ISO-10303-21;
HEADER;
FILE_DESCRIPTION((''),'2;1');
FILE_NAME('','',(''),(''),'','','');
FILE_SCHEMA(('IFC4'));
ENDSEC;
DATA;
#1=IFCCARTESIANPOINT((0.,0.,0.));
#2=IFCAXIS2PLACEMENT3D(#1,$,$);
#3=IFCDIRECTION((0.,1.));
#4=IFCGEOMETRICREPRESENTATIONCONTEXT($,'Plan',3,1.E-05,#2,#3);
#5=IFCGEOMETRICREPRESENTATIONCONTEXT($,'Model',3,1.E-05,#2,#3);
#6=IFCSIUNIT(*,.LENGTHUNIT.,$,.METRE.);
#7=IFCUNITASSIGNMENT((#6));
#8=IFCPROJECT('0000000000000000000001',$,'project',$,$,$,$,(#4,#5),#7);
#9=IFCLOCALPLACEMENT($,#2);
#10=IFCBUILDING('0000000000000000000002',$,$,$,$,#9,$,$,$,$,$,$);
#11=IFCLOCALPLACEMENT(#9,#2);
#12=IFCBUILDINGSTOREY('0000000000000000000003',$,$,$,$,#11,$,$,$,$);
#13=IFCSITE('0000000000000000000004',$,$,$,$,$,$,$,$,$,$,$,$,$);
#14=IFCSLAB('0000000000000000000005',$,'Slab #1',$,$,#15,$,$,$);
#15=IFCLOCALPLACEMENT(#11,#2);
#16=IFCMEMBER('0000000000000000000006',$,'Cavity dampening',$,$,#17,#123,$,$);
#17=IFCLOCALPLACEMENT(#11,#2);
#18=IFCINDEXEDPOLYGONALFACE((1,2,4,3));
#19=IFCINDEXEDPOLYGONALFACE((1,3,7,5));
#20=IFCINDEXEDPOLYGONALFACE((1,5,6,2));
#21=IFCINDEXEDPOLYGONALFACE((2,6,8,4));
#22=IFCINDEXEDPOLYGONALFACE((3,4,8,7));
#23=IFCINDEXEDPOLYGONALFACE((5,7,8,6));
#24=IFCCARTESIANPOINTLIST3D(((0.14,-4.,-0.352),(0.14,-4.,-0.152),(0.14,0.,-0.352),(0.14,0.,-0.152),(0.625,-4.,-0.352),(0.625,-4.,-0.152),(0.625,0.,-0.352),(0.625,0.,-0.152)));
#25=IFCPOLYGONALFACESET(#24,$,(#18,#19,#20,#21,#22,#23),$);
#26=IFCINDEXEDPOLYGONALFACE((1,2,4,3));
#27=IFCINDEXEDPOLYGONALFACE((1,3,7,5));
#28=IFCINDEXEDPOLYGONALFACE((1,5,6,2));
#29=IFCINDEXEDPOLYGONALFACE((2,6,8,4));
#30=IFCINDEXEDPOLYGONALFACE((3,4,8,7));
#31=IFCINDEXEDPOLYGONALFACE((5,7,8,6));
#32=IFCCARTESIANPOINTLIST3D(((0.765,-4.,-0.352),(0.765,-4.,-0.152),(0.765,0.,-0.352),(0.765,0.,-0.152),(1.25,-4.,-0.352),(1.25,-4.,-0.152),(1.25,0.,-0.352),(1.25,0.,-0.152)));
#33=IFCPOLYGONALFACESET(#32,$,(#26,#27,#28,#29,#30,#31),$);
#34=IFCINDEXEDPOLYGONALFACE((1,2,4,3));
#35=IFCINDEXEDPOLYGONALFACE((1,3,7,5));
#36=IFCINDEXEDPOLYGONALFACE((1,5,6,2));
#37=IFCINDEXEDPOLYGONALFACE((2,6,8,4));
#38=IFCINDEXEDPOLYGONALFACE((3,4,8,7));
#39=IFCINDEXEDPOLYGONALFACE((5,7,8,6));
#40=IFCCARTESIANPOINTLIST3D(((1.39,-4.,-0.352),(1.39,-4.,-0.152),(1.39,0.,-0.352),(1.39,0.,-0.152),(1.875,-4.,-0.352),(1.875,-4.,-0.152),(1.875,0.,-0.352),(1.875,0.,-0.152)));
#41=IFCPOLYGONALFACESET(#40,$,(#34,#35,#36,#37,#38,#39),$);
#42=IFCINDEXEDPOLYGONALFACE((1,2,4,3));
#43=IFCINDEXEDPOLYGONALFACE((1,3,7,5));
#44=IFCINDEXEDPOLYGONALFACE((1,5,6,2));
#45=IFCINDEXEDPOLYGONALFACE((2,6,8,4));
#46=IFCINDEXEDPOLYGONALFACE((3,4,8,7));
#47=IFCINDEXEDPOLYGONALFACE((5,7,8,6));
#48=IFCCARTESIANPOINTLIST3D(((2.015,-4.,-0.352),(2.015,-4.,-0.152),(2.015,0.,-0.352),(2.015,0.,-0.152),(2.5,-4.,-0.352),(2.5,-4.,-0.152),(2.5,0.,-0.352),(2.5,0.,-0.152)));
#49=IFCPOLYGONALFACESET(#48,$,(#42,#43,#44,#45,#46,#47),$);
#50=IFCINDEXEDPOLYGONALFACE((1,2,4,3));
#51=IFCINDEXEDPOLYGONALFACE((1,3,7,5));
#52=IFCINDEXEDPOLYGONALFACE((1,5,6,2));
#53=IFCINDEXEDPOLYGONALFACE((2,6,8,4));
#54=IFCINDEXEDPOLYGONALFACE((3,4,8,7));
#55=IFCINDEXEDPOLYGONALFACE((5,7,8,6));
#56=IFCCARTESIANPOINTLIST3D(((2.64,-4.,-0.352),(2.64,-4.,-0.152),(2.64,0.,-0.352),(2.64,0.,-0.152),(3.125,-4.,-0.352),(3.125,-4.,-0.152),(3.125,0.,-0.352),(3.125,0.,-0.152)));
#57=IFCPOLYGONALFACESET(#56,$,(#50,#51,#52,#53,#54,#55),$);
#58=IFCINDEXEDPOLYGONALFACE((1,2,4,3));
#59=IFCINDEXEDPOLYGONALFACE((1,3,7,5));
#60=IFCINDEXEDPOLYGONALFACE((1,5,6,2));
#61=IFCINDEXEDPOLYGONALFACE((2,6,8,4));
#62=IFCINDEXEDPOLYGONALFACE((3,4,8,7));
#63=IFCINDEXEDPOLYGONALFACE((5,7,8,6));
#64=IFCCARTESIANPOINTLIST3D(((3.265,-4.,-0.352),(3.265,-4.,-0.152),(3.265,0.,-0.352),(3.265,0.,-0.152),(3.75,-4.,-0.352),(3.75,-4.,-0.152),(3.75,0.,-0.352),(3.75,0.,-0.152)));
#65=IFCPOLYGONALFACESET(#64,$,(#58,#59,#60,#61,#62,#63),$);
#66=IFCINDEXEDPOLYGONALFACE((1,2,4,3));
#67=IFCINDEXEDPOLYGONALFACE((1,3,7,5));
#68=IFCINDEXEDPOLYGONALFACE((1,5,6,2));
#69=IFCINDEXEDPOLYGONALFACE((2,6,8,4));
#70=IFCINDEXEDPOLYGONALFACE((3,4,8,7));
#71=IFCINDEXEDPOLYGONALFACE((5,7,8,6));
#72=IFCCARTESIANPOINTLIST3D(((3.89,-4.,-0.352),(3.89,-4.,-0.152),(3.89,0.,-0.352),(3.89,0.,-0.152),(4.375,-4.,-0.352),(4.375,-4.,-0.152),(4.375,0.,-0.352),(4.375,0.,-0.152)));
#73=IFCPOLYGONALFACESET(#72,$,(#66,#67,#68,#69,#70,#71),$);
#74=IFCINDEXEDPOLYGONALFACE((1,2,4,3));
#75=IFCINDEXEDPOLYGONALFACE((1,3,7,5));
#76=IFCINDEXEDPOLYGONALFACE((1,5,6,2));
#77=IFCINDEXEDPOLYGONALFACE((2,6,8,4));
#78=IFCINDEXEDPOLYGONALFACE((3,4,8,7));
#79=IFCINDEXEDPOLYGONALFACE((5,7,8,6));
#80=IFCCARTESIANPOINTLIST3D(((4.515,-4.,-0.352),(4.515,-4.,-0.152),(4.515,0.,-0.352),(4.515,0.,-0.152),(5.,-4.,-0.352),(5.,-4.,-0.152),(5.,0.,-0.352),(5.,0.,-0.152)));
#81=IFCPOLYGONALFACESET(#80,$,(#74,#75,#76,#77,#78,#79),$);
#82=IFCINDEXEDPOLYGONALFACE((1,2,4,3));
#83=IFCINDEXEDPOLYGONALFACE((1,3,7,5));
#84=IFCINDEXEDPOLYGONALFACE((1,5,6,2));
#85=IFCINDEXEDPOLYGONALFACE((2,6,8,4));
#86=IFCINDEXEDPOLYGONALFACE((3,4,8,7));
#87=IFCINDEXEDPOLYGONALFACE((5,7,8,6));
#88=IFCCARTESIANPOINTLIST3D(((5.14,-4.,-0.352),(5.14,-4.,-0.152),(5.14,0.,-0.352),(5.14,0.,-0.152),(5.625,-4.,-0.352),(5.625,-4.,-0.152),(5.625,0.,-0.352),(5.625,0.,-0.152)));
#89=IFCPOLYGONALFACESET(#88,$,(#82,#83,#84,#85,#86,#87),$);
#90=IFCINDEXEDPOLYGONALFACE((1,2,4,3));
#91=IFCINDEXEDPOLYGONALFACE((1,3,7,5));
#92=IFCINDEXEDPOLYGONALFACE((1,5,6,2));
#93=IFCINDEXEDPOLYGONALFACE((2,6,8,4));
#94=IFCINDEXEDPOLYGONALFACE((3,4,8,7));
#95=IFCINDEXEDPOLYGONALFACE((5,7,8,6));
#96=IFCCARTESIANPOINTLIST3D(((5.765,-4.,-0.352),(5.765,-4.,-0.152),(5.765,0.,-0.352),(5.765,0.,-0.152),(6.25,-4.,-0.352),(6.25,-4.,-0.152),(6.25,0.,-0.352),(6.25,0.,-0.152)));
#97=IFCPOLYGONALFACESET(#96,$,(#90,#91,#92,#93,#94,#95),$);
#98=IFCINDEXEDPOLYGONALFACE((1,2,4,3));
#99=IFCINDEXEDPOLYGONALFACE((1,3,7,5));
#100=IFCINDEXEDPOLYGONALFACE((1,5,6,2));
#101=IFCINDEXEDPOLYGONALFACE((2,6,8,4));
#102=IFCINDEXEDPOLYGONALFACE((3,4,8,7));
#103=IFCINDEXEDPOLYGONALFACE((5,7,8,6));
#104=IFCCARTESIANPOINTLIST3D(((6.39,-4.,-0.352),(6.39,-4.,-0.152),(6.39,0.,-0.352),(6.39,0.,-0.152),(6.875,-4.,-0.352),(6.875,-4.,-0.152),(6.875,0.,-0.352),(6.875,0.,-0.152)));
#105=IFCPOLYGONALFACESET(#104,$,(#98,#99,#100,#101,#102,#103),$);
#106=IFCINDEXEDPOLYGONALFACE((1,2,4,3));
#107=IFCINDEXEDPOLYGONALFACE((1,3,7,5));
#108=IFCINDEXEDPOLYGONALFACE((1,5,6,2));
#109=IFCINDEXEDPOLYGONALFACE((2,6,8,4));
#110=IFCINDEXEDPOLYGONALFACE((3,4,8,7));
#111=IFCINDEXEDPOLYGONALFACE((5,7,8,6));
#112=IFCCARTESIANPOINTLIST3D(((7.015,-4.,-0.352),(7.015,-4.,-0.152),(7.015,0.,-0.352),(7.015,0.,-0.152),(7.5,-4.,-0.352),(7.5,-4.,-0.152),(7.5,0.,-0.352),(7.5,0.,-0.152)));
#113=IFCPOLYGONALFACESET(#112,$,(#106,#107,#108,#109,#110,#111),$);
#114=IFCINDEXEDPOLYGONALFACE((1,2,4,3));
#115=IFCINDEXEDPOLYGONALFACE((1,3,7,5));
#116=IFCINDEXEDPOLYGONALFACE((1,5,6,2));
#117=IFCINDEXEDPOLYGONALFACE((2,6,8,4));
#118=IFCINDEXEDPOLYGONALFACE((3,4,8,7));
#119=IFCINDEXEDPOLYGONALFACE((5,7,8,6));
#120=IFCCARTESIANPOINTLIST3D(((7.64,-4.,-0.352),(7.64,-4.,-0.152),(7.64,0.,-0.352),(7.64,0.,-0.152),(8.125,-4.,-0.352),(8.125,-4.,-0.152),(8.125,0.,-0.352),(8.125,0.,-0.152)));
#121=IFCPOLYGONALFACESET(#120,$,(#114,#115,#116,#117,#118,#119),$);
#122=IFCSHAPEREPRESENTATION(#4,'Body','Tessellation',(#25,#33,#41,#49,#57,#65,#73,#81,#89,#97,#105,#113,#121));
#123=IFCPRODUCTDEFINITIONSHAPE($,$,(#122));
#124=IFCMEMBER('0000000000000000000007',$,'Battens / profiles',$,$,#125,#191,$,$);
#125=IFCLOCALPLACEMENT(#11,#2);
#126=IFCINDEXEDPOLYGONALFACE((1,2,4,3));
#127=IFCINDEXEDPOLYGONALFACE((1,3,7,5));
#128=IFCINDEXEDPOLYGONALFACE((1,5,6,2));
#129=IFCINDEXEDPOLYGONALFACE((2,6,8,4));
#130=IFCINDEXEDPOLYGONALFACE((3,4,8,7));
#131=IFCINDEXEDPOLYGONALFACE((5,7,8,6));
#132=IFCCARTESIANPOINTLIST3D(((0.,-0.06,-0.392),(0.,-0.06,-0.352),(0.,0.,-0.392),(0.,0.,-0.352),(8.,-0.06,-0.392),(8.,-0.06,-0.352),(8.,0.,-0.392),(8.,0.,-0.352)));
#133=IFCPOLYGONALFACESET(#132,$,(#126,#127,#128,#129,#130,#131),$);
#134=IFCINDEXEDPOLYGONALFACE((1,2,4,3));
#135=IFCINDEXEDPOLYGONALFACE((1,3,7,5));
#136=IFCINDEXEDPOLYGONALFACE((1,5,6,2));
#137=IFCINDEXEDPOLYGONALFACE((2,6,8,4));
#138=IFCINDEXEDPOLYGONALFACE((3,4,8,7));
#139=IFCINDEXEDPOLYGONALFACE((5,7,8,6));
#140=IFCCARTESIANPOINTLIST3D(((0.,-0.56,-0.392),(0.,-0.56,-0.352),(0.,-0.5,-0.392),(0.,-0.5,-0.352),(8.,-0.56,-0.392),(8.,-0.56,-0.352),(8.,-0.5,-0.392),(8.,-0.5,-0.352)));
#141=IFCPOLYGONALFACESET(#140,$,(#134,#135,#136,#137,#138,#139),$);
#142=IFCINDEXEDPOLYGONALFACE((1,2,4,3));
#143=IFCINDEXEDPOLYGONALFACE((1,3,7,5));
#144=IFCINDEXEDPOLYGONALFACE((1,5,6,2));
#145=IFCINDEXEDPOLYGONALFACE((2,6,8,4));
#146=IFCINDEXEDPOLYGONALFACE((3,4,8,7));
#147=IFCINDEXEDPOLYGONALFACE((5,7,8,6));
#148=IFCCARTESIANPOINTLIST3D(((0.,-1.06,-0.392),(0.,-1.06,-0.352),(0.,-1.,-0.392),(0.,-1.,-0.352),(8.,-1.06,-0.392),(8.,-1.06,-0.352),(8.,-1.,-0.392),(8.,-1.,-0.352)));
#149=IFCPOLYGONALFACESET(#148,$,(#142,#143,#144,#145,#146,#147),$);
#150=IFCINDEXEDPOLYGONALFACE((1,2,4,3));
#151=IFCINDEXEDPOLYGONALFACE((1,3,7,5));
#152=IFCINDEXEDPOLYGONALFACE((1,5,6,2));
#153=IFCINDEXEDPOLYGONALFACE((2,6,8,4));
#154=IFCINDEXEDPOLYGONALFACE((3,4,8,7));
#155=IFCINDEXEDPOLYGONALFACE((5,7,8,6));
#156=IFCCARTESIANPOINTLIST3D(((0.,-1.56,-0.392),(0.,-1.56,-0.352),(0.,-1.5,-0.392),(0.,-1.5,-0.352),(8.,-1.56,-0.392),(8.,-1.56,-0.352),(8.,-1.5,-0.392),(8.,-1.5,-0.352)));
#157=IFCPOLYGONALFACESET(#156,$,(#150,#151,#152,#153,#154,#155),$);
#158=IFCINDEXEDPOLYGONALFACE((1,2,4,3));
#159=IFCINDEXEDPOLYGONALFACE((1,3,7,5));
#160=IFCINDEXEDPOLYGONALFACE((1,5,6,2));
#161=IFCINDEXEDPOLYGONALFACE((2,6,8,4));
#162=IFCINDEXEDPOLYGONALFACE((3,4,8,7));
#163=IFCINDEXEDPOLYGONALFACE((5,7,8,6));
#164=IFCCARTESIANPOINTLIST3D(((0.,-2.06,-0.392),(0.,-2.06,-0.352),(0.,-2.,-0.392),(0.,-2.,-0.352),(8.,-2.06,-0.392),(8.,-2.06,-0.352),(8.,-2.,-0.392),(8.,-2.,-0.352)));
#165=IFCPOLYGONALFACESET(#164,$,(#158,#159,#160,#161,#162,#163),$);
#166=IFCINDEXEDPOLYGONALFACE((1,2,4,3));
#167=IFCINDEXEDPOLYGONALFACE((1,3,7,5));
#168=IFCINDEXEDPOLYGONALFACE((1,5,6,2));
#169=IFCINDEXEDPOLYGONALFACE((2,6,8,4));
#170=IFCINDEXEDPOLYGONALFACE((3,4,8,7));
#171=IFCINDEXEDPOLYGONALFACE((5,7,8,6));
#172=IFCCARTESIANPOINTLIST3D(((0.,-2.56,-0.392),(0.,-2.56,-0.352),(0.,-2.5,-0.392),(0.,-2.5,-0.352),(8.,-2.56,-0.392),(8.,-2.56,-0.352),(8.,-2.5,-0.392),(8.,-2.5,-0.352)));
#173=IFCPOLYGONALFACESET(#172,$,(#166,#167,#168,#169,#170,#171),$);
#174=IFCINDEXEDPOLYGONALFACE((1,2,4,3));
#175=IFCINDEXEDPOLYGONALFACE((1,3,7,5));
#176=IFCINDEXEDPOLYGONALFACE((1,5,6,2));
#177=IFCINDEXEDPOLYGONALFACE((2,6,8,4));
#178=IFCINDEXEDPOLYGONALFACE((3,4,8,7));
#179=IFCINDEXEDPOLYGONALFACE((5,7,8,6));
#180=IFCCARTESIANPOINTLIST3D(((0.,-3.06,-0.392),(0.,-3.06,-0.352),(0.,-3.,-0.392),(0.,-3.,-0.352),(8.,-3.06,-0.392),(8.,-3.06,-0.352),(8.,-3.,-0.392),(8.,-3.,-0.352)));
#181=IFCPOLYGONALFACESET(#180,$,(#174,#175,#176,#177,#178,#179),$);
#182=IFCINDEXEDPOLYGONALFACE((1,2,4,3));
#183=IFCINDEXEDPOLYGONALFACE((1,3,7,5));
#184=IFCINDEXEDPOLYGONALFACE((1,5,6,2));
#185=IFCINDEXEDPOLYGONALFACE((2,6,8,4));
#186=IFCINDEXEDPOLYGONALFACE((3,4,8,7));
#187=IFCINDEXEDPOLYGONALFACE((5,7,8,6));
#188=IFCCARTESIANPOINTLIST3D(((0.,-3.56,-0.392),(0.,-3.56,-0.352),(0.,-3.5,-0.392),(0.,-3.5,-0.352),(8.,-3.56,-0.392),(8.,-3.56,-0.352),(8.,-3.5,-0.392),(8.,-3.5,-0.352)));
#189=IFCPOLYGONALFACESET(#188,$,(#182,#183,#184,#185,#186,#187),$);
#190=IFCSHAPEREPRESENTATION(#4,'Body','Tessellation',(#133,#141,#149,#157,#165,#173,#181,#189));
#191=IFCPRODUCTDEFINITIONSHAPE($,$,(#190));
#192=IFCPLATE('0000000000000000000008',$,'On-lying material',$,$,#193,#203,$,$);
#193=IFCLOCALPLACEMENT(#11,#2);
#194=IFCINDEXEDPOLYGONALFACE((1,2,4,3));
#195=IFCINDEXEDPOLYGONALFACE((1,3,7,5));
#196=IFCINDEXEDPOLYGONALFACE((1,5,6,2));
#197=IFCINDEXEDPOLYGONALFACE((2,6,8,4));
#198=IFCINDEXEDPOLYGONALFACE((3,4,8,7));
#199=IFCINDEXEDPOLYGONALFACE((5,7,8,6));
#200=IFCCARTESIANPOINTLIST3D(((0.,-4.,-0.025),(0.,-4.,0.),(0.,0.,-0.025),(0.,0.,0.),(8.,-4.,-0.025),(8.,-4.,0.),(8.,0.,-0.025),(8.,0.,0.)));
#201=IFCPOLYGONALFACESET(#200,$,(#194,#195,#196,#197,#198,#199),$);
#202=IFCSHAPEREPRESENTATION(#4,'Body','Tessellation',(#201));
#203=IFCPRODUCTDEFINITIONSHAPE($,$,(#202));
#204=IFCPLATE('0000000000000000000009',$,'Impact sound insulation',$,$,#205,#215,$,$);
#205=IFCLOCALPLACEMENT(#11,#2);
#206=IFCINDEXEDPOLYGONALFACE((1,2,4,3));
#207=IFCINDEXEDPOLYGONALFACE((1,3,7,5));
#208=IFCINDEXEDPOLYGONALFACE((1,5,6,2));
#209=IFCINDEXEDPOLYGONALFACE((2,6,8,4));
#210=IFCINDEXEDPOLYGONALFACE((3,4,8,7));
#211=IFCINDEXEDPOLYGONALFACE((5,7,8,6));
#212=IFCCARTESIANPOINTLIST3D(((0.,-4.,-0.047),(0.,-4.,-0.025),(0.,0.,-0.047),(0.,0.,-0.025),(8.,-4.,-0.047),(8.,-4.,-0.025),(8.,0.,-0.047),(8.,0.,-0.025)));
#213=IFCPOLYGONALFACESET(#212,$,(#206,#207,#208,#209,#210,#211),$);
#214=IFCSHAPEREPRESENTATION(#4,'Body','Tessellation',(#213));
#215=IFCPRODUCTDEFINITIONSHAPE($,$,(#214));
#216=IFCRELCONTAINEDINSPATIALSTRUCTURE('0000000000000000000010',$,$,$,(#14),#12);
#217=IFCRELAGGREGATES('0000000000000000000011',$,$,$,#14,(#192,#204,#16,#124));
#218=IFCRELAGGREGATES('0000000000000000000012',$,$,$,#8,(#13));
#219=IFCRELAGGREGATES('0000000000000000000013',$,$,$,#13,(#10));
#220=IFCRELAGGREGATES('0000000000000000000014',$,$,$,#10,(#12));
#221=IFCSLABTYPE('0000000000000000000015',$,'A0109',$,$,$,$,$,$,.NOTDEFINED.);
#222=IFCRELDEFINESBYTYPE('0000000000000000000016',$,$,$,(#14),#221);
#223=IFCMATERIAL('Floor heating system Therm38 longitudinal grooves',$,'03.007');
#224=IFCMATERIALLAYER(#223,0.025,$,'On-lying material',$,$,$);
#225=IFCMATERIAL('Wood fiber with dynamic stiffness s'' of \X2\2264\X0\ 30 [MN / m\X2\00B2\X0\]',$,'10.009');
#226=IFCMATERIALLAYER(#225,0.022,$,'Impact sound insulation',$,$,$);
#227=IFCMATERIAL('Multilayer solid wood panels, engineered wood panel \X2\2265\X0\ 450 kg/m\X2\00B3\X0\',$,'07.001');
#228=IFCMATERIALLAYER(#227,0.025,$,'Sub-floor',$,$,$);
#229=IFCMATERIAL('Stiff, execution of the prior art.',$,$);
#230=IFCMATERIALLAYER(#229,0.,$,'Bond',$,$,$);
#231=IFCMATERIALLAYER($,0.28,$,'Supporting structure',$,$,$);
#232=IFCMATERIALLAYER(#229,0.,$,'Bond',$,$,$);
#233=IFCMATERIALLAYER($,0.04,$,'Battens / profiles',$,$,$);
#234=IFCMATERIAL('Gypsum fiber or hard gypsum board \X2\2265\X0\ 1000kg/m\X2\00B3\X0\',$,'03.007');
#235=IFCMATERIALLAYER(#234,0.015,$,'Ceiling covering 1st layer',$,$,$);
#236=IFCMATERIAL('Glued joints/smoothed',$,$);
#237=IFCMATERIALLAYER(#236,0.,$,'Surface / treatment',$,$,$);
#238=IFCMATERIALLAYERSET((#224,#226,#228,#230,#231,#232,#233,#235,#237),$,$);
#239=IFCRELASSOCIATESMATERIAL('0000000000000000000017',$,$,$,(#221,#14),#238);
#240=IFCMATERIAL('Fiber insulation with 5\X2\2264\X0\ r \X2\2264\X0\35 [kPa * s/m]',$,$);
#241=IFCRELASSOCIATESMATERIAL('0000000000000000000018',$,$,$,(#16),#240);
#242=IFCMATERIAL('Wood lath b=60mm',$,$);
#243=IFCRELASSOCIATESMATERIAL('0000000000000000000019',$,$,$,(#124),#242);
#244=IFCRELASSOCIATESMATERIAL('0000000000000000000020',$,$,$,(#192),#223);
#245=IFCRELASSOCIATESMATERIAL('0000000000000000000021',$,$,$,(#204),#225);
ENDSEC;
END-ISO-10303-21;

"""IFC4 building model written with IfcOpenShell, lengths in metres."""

from ifc_helpers import new_model, si_unit, direction, frame, frame_2d, origin, origin_with_axes, place, context, project, spatial, rectangle, extrude, material, layer, layer_set, type_object, element, aggregate, save


model = new_model("IFC4")

# Units and contexts
plan_context = context("Plan", 3, precision=1e-05, world=origin(), true_north=direction((0.0, 1.0)))
model_context = context("Model", 3, precision=1e-05, world=origin(), true_north=direction((0.0, 1.0)))
ifc_project = project(units=[si_unit("LENGTHUNIT", "METRE")], contexts=[plan_context, model_context])

# Site, building, storey
site = spatial("IfcSite", under=ifc_project)
building_placement = place(None, origin())
building = spatial("IfcBuilding", under=site, at=building_placement)
storey_placement = place(building_placement, origin())
storey = spatial("IfcBuildingStorey", under=building, at=storey_placement)

# Slab, members, plates
ifc_material_1 = material(Name="Floor heating system Therm38 longitudinal grooves", Category="03.007")
ifc_layer_1 = layer(ifc_material_1, 0.025, Name="On-lying material")
ifc_material_2 = material(Name="Wood fiber with dynamic stiffness s' of ≤ 30 [MN / m²]", Category="10.009")
ifc_layer_2 = layer(ifc_material_2, 0.022, Name="Impact sound insulation")
ifc_material_3 = material(Name="Multilayer solid wood panels, engineered wood panel ≥ 450 kg/m³", Category="07.001")
ifc_layer_3 = layer(ifc_material_3, 0.025, Name="Sub-floor")
ifc_material_4 = material(Name="Stiff, execution of the prior art.")
ifc_layer_4 = layer(ifc_material_4, 0.0, Name="Bond")
ifc_layer_5 = layer(None, 0.28, Name="Supporting structure")
ifc_layer_6 = layer(ifc_material_4, 0.0, Name="Bond")
ifc_layer_7 = layer(None, 0.04, Name="Battens / profiles")
ifc_material_5 = material(Name="Gypsum fiber or hard gypsum board ≥ 1000kg/m³", Category="03.007")
ifc_layer_8 = layer(ifc_material_5, 0.015, Name="Ceiling covering 1st layer")
ifc_material_6 = material(Name="Glued joints/smoothed")
ifc_layer_9 = layer(ifc_material_6, 0.0, Name="Surface / treatment")
ifc_layer_set = layer_set([ifc_layer_1, ifc_layer_2, ifc_layer_3, ifc_layer_4, ifc_layer_5, ifc_layer_6, ifc_layer_7, ifc_layer_8, ifc_layer_9])
slab_type = type_object("IfcSlabType", Name="A0109", PredefinedType="NOTDEFINED", material=ifc_layer_set)
slab_placement = place(None, frame((0.0, 0.0, 0.0), z_axis=(0.0, 0.0, -1.0), x_axis=(1.0, 0.0, 0.0)))
slab = element("IfcSlab", 1, at=slab_placement, inside=storey, type_object=slab_type, material=ifc_layer_set, Name="Slab #1")
ifc_material_7 = material(Name="Fiber insulation with 5≤ r ≤35 [kPa * s/m]")
member_1_placement = place(slab_placement, origin())
member_1 = element("IfcMember", 2, at=member_1_placement, material=ifc_material_7, Name="Cavity dampening", context=plan_context, shape_type="SweptSolid", body=[
    extrude(rectangle(XDim=0.485, YDim=0.2, at=frame_2d((0.2425, 0.1), x_axis=(1.0, 0.0))), frame((0.14, 4.0, 0.152), z_axis=(0.0, -1.0, 0.0), x_axis=(1.0, 0.0, 0.0)), (0.0, 0.0, 1.0), 4.0),
    extrude(rectangle(XDim=0.485, YDim=0.2, at=frame_2d((0.2425, 0.1), x_axis=(1.0, 0.0))), frame((0.765, 4.0, 0.152), z_axis=(0.0, -1.0, 0.0), x_axis=(1.0, 0.0, 0.0)), (0.0, 0.0, 1.0), 4.0),
    extrude(rectangle(XDim=0.485, YDim=0.2, at=frame_2d((0.2425, 0.1), x_axis=(1.0, 0.0))), frame((1.39, 4.0, 0.152), z_axis=(0.0, -1.0, 0.0), x_axis=(1.0, 0.0, 0.0)), (0.0, 0.0, 1.0), 4.0),
    extrude(rectangle(XDim=0.485, YDim=0.2, at=frame_2d((0.2425, 0.1), x_axis=(1.0, 0.0))), frame((2.015, 4.0, 0.152), z_axis=(0.0, -1.0, 0.0), x_axis=(1.0, 0.0, 0.0)), (0.0, 0.0, 1.0), 4.0),
    extrude(rectangle(XDim=0.485, YDim=0.2, at=frame_2d((0.2425, 0.1), x_axis=(1.0, 0.0))), frame((2.64, 4.0, 0.152), z_axis=(0.0, -1.0, 0.0), x_axis=(1.0, 0.0, 0.0)), (0.0, 0.0, 1.0), 4.0),
    extrude(rectangle(XDim=0.485, YDim=0.2, at=frame_2d((0.2425, 0.1), x_axis=(1.0, 0.0))), frame((3.265, 4.0, 0.152), z_axis=(0.0, -1.0, 0.0), x_axis=(1.0, 0.0, 0.0)), (0.0, 0.0, 1.0), 4.0),
    extrude(rectangle(XDim=0.485, YDim=0.2, at=frame_2d((0.2425, 0.1), x_axis=(1.0, 0.0))), frame((3.89, 4.0, 0.152), z_axis=(0.0, -1.0, 0.0), x_axis=(1.0, 0.0, 0.0)), (0.0, 0.0, 1.0), 4.0),
    extrude(rectangle(XDim=0.485, YDim=0.2, at=frame_2d((0.2425, 0.1), x_axis=(1.0, 0.0))), frame((4.515, 4.0, 0.152), z_axis=(0.0, -1.0, 0.0), x_axis=(1.0, 0.0, 0.0)), (0.0, 0.0, 1.0), 4.0),
    extrude(rectangle(XDim=0.485, YDim=0.2, at=frame_2d((0.2425, 0.1), x_axis=(1.0, 0.0))), frame((5.14, 4.0, 0.152), z_axis=(0.0, -1.0, 0.0), x_axis=(1.0, 0.0, 0.0)), (0.0, 0.0, 1.0), 4.0),
    extrude(rectangle(XDim=0.485, YDim=0.2, at=frame_2d((0.2425, 0.1), x_axis=(1.0, 0.0))), frame((5.765, 4.0, 0.152), z_axis=(0.0, -1.0, 0.0), x_axis=(1.0, 0.0, 0.0)), (0.0, 0.0, 1.0), 4.0),
    extrude(rectangle(XDim=0.485, YDim=0.2, at=frame_2d((0.2425, 0.1), x_axis=(1.0, 0.0))), frame((6.39, 4.0, 0.152), z_axis=(0.0, -1.0, 0.0), x_axis=(1.0, 0.0, 0.0)), (0.0, 0.0, 1.0), 4.0),
    extrude(rectangle(XDim=0.485, YDim=0.2, at=frame_2d((0.2425, 0.1), x_axis=(1.0, 0.0))), frame((7.015, 4.0, 0.152), z_axis=(0.0, -1.0, 0.0), x_axis=(1.0, 0.0, 0.0)), (0.0, 0.0, 1.0), 4.0),
    extrude(rectangle(XDim=0.485, YDim=0.2, at=frame_2d((0.2425, 0.1), x_axis=(1.0, 0.0))), frame((7.64, 4.0, 0.152), z_axis=(0.0, -1.0, 0.0), x_axis=(1.0, 0.0, 0.0)), (0.0, 0.0, 1.0), 4.0),
])
ifc_material_8 = material(Name="Wood lath b=60mm")
member_2_placement = place(slab_placement, origin())
member_2 = element("IfcMember", 3, at=member_2_placement, material=ifc_material_8, Name="Battens / profiles", context=plan_context, shape_type="SweptSolid", body=[
    extrude(rectangle(XDim=0.06, YDim=0.04, at=frame_2d((0.03, 0.02), x_axis=(1.0, 0.0))), frame((0.0, 0.0, 0.352), z_axis=(1.0, 0.0, 0.0), x_axis=(0.0, 1.0, 0.0)), (0.0, 0.0, 1.0), 8.0),
    extrude(rectangle(XDim=0.06, YDim=0.04, at=frame_2d((0.03, 0.02), x_axis=(1.0, 0.0))), frame((0.0, 0.5, 0.352), z_axis=(1.0, 0.0, 0.0), x_axis=(0.0, 1.0, 0.0)), (0.0, 0.0, 1.0), 8.0),
    extrude(rectangle(XDim=0.06, YDim=0.04, at=frame_2d((0.03, 0.02), x_axis=(1.0, 0.0))), frame((0.0, 1.0, 0.352), z_axis=(1.0, 0.0, 0.0), x_axis=(0.0, 1.0, 0.0)), (0.0, 0.0, 1.0), 8.0),
    extrude(rectangle(XDim=0.06, YDim=0.04, at=frame_2d((0.03, 0.02), x_axis=(1.0, 0.0))), frame((0.0, 1.5, 0.352), z_axis=(1.0, 0.0, 0.0), x_axis=(0.0, 1.0, 0.0)), (0.0, 0.0, 1.0), 8.0),
    extrude(rectangle(XDim=0.06, YDim=0.04, at=frame_2d((0.03, 0.02), x_axis=(1.0, 0.0))), frame((0.0, 2.0, 0.352), z_axis=(1.0, 0.0, 0.0), x_axis=(0.0, 1.0, 0.0)), (0.0, 0.0, 1.0), 8.0),
    extrude(rectangle(XDim=0.06, YDim=0.04, at=frame_2d((0.03, 0.02), x_axis=(1.0, 0.0))), frame((0.0, 2.5, 0.352), z_axis=(1.0, 0.0, 0.0), x_axis=(0.0, 1.0, 0.0)), (0.0, 0.0, 1.0), 8.0),
    extrude(rectangle(XDim=0.06, YDim=0.04, at=frame_2d((0.03, 0.02), x_axis=(1.0, 0.0))), frame((0.0, 3.0, 0.352), z_axis=(1.0, 0.0, 0.0), x_axis=(0.0, 1.0, 0.0)), (0.0, 0.0, 1.0), 8.0),
    extrude(rectangle(XDim=0.06, YDim=0.04, at=frame_2d((0.03, 0.02), x_axis=(1.0, 0.0))), frame((0.0, 3.5, 0.352), z_axis=(1.0, 0.0, 0.0), x_axis=(0.0, 1.0, 0.0)), (0.0, 0.0, 1.0), 8.0),
])
plate_1_placement = place(slab_placement, origin())
plate_1 = element("IfcPlate", 4, at=plate_1_placement, material=ifc_material_1, Name="On-lying material", context=plan_context, shape_type="SweptSolid", body=[
    extrude(rectangle(XDim=8.0, YDim=4.0, at=frame_2d((4.0, 2.0), x_axis=(1.0, 0.0))), origin_with_axes(), (0.0, 0.0, 1.0), 0.025),
])
plate_2_placement = place(slab_placement, origin())
plate_2 = element("IfcPlate", 5, at=plate_2_placement, material=ifc_material_2, Name="Impact sound insulation", context=plan_context, shape_type="SweptSolid", body=[
    extrude(rectangle(XDim=8.0, YDim=4.0, at=frame_2d((4.0, 2.0), x_axis=(1.0, 0.0))), frame((0.0, 0.0, 0.025), z_axis=(0.0, 0.0, 1.0), x_axis=(1.0, 0.0, 0.0)), (0.0, 0.0, 1.0), 0.022),
])
aggregate(slab, [plate_1, plate_2, member_1, member_2])

save(model, "model.ifc")
